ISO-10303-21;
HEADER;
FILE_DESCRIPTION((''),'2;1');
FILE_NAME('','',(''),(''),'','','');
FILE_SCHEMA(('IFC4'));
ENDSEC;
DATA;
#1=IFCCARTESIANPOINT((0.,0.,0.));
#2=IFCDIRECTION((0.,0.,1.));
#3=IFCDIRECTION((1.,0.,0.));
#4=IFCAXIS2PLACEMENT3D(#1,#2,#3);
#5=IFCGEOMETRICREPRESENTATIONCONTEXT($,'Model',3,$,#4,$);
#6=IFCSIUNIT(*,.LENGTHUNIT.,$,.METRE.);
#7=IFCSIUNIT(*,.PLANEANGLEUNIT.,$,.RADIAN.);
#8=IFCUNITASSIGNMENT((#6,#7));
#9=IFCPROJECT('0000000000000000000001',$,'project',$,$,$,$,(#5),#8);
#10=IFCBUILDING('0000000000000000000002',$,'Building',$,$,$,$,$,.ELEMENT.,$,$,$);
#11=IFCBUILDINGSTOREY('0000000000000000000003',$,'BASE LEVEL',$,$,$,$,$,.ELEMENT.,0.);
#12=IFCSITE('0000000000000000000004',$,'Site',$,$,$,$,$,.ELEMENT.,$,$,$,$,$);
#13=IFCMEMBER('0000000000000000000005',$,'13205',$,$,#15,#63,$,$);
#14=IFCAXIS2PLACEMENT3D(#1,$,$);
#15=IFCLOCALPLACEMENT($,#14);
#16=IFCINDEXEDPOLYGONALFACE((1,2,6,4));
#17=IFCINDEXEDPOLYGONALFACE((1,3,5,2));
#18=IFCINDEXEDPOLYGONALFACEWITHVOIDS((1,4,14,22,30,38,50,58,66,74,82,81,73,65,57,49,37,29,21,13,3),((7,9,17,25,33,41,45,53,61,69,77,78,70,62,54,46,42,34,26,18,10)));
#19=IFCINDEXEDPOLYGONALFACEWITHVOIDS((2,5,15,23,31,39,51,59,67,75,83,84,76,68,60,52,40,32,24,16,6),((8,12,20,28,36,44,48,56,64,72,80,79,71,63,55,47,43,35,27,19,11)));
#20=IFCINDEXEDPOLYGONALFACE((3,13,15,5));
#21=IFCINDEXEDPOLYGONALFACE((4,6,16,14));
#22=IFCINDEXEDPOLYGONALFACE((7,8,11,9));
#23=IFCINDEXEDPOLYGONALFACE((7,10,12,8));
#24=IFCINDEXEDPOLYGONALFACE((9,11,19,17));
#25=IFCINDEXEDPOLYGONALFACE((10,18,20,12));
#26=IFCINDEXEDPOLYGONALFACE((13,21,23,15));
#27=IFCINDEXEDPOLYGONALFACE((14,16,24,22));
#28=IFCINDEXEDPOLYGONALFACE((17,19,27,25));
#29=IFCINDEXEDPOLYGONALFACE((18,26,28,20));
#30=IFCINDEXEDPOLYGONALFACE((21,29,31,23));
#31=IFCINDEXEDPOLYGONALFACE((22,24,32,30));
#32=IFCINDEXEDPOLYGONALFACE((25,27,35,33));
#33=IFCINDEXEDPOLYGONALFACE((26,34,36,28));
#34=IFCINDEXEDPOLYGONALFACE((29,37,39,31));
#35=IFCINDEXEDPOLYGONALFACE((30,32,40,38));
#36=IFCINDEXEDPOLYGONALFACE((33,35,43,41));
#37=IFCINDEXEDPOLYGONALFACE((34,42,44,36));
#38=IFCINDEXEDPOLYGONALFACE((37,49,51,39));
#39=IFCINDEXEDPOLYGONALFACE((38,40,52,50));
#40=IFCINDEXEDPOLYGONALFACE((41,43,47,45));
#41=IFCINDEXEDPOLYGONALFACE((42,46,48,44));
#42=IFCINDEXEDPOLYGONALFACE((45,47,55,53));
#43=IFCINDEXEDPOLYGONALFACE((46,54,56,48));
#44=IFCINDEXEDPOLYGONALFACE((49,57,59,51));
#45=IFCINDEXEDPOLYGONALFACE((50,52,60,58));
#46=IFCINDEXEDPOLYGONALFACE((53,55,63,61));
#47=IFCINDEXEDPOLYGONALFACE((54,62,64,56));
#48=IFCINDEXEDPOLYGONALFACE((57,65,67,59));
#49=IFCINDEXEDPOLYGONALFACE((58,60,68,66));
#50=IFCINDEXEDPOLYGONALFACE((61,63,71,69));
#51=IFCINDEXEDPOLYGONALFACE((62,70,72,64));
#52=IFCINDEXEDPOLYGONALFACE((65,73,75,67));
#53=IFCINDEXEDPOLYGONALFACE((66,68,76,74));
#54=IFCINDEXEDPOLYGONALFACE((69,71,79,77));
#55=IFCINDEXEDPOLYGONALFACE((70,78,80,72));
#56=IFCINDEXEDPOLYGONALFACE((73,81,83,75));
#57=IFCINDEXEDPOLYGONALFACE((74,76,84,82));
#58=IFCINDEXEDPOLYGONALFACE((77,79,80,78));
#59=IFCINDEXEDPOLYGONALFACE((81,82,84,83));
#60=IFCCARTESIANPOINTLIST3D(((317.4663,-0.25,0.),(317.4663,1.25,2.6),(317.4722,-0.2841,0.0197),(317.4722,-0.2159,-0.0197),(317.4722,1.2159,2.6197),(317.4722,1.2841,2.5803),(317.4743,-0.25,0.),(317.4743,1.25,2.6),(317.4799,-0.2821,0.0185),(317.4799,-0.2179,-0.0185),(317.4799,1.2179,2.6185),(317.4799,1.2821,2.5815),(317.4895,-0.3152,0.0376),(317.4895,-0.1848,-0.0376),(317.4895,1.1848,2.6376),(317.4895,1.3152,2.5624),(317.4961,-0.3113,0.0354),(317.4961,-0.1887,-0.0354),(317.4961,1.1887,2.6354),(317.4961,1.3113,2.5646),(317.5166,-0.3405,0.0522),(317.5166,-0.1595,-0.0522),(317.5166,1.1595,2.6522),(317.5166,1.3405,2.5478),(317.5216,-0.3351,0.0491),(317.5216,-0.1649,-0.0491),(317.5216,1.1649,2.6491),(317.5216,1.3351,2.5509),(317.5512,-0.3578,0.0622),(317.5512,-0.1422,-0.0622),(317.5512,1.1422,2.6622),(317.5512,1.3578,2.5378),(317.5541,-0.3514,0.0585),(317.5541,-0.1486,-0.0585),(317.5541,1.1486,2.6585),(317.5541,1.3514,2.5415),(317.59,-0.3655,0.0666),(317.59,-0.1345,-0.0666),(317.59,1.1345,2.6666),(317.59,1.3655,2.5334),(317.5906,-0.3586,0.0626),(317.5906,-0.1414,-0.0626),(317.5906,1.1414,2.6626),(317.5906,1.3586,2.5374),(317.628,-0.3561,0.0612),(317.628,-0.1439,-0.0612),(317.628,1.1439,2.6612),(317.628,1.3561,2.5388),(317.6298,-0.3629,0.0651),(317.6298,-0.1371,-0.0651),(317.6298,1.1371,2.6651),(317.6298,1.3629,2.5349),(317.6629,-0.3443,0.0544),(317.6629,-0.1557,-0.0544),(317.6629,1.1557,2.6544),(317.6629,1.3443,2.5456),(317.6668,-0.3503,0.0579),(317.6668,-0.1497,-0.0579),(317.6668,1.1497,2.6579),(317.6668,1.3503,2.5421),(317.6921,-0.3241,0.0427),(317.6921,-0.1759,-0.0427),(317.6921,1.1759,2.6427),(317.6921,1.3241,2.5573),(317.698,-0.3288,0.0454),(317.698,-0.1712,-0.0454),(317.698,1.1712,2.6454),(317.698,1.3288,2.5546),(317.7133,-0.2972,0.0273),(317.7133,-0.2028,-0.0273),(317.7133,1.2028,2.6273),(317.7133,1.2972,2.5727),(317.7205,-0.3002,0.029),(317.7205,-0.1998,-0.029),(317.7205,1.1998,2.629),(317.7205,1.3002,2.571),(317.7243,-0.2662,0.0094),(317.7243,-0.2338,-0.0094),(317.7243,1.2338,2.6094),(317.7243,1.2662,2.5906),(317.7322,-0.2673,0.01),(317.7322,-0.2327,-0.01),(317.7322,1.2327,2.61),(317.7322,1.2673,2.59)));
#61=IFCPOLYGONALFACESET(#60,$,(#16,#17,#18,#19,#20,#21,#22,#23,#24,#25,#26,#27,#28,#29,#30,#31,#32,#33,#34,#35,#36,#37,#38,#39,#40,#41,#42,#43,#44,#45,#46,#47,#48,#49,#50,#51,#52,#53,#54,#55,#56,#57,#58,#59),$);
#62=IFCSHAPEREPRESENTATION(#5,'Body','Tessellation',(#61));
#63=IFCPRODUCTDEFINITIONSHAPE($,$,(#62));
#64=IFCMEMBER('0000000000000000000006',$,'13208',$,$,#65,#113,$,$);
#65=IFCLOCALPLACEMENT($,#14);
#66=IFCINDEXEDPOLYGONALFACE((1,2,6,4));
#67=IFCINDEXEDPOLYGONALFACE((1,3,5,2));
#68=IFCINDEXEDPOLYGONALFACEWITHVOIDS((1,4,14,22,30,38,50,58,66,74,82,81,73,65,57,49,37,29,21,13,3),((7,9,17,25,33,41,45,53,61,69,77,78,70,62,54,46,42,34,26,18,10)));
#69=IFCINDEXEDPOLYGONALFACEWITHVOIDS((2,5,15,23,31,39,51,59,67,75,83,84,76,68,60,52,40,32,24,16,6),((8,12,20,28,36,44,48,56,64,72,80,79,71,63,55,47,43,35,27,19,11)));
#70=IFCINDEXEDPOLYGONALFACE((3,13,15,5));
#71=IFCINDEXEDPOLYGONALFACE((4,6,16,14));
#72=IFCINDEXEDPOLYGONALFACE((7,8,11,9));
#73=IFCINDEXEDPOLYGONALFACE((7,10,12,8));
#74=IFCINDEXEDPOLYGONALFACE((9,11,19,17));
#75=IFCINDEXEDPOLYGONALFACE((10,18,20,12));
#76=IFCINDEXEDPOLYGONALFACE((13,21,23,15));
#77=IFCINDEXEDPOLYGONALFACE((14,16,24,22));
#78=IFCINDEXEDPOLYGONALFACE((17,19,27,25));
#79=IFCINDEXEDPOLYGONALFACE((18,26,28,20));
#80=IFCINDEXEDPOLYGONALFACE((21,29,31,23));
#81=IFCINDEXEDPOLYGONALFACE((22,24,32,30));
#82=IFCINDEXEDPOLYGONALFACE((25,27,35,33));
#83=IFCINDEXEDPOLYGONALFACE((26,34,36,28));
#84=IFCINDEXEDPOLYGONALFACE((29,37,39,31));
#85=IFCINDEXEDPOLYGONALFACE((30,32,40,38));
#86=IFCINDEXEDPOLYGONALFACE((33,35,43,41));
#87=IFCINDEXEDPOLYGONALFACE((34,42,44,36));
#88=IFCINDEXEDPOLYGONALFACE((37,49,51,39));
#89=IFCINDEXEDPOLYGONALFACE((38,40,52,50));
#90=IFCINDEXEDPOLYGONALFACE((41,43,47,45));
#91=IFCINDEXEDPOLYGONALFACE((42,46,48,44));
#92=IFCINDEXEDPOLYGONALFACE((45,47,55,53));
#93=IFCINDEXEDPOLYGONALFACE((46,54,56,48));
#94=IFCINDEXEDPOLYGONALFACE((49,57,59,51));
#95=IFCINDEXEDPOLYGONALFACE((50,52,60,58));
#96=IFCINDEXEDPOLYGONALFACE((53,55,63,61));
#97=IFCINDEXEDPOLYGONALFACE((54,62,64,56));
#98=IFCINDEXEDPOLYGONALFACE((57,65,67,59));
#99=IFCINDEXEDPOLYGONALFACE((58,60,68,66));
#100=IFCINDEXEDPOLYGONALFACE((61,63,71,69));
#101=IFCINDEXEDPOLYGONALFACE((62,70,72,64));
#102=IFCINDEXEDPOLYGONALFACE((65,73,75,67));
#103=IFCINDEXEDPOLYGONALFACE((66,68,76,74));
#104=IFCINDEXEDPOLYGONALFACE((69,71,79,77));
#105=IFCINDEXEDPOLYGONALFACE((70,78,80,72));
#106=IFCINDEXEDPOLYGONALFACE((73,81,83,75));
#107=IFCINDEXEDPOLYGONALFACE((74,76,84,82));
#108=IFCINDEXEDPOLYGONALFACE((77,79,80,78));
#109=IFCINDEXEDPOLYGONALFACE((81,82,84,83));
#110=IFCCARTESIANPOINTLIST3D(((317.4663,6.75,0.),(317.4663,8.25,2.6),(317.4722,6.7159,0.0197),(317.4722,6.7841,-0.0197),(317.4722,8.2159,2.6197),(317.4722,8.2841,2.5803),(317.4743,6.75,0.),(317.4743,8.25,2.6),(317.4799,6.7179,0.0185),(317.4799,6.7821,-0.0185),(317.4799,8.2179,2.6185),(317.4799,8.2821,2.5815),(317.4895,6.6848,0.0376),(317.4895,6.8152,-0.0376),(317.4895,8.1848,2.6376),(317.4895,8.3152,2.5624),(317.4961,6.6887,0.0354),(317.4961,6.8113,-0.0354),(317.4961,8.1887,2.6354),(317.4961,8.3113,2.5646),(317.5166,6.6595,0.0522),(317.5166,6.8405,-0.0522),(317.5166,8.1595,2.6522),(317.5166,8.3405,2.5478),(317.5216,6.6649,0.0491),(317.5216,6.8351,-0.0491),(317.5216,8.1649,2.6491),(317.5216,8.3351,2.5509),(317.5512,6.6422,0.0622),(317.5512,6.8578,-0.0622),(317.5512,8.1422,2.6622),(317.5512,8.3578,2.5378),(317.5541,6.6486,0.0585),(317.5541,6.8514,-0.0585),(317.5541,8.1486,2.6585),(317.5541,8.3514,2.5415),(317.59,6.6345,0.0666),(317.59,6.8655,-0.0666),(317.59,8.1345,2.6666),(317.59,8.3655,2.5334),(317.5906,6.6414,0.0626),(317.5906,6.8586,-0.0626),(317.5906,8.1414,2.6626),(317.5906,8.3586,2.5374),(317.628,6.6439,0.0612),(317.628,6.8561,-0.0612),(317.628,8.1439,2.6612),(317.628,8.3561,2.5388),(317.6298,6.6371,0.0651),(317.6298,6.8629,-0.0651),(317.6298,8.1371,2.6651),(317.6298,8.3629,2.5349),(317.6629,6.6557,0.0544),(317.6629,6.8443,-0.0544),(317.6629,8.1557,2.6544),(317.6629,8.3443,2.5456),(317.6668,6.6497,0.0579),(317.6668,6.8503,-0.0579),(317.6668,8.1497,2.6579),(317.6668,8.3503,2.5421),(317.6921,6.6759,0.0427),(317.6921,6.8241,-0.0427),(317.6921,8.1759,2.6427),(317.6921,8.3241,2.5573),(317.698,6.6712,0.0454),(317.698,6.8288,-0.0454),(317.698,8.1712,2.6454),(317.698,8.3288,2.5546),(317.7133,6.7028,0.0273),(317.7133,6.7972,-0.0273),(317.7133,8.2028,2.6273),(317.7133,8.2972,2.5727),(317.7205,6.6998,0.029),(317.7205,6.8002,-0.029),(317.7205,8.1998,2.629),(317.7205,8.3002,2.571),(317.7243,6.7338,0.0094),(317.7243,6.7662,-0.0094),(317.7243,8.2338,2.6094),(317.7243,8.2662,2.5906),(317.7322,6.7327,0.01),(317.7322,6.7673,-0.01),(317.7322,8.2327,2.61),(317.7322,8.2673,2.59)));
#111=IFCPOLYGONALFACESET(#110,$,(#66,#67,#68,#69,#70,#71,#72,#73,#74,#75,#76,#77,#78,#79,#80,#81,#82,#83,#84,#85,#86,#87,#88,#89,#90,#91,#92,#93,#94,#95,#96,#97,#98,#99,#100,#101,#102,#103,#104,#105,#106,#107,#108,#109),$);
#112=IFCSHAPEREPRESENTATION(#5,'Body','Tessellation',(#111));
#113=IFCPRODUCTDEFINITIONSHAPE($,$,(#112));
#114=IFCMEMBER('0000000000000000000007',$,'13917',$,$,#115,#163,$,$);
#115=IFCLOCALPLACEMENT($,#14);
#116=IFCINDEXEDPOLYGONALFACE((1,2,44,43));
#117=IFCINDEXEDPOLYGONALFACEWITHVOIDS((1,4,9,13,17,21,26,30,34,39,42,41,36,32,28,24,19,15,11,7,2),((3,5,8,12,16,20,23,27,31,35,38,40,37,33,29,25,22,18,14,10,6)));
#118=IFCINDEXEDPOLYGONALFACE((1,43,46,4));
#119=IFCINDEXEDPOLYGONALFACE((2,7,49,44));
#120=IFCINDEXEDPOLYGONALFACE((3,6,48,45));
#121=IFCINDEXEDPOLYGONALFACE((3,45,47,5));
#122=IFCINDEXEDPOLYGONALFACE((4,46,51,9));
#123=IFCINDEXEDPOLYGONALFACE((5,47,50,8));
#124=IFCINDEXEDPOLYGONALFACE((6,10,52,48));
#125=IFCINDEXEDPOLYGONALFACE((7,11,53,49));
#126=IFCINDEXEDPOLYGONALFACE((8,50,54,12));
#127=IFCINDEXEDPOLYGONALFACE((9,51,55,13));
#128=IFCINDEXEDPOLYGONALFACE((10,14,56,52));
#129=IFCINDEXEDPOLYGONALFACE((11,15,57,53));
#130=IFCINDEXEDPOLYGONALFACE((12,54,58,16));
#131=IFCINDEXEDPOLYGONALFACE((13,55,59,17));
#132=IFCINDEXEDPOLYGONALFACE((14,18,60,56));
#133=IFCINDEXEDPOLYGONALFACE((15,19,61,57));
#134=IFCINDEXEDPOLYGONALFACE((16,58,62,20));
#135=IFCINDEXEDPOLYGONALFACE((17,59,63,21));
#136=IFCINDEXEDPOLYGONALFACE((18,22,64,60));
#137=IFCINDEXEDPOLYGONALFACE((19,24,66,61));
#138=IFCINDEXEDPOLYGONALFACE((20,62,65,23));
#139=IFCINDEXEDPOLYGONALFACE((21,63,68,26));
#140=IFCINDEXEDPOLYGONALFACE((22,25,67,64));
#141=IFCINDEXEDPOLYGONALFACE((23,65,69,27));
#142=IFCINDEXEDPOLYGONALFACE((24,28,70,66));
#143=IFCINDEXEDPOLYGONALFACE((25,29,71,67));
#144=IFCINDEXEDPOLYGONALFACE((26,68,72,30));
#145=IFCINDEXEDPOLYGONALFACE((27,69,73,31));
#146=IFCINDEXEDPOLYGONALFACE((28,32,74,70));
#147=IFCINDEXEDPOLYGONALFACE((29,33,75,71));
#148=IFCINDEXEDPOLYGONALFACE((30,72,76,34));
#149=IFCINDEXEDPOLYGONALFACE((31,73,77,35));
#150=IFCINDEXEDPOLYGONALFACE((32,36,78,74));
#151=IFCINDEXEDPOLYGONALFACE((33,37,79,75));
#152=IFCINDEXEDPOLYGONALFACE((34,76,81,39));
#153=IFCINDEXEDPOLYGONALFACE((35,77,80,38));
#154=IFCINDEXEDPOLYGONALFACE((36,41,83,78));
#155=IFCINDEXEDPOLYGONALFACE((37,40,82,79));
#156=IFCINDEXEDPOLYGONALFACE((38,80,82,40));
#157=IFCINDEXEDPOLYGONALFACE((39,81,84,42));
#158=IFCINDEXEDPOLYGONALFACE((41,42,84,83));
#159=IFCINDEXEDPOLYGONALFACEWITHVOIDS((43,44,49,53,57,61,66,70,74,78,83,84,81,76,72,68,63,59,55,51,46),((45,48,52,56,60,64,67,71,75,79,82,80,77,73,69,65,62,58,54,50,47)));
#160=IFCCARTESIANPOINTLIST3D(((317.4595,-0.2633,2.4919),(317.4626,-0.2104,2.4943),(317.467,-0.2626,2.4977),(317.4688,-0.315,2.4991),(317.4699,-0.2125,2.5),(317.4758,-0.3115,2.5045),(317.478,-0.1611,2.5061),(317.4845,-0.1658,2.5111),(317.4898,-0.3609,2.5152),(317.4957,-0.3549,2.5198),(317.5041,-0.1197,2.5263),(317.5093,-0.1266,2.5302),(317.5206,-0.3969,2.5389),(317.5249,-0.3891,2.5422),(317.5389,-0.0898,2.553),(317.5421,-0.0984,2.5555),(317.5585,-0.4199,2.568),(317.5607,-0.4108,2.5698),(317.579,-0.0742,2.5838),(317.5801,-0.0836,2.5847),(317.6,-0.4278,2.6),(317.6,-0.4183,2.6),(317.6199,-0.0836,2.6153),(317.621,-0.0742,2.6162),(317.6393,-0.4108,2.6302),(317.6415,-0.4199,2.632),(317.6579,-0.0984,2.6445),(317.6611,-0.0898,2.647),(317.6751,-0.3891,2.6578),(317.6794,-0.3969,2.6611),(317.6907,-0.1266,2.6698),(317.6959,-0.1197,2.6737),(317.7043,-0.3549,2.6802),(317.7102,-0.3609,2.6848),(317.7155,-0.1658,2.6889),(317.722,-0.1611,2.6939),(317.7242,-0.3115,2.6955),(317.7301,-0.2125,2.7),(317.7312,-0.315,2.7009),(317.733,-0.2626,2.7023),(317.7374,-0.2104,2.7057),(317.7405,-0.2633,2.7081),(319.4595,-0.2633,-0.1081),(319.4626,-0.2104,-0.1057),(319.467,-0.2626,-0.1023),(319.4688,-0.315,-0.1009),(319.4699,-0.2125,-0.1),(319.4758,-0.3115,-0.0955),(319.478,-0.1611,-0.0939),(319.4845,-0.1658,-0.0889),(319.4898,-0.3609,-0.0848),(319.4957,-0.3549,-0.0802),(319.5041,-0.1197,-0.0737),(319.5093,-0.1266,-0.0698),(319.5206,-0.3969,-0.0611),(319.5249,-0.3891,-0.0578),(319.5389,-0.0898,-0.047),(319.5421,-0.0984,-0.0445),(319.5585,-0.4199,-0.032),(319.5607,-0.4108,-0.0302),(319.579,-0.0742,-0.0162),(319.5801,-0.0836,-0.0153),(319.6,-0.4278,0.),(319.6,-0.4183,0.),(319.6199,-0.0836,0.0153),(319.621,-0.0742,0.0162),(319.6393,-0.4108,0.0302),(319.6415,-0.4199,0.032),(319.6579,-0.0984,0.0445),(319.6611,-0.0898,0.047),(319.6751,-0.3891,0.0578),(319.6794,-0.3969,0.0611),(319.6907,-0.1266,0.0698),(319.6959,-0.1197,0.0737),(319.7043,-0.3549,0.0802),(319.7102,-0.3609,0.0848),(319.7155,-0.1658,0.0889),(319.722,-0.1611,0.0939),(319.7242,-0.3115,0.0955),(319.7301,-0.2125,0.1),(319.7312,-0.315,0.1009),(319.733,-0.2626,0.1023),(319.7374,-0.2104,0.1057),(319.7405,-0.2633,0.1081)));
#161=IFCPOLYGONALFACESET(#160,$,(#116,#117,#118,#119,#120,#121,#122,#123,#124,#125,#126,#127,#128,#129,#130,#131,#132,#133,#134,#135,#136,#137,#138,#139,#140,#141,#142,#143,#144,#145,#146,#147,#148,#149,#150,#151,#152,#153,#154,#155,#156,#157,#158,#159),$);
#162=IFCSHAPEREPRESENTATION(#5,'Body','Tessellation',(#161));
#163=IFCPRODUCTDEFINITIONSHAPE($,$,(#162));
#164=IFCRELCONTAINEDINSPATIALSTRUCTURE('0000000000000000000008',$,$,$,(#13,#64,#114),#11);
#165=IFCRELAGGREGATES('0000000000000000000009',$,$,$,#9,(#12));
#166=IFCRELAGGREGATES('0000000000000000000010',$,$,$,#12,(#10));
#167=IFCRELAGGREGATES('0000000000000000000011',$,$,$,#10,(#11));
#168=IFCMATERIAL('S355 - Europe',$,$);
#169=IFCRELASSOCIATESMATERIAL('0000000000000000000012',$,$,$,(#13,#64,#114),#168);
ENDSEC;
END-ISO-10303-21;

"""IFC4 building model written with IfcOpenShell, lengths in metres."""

from ifc_helpers import new_model, si_unit, frame, origin_with_axes, origin_2d_with_axis, place, context, project, spatial, hollow_circle, extrude, material, material_profile, profile_set, profile_usage, element, save


model = new_model("IFC4")

# Units and contexts
model_context = context("Model", 3, world=origin_with_axes())
ifc_project = project(units=[si_unit("LENGTHUNIT", "METRE"), si_unit("PLANEANGLEUNIT", "RADIAN")], contexts=[model_context])

# Site, building, storey
site = spatial("IfcSite", under=ifc_project, Name="Site", CompositionType="ELEMENT")
building = spatial("IfcBuilding", under=site, Name="Building", CompositionType="ELEMENT")
storey = spatial("IfcBuildingStorey", under=building, Name="BASE LEVEL", CompositionType="ELEMENT", Elevation=0.0)

# Shared definitions
ifc_material = material(Name="S355 - Europe")

# Members
ifc_material_profile_1 = material_profile(ifc_material, hollow_circle(Radius=0.1337, WallThickness=0.008, at=origin_2d_with_axis()))
ifc_profile_set_1 = profile_set([ifc_material_profile_1])
ifc_profile_usage_1 = profile_usage(ifc_profile_set_1, cardinal=10)
member_1_placement = place(None, frame((317.6, -0.25, 0.0), z_axis=(0.0, 0.499722, 0.866186), x_axis=(-1.0, 0.0, 0.0)))
element("IfcMember", 1, at=member_1_placement, inside=storey, material=ifc_profile_usage_1, Name="13205", context=model_context, shape_type="SweptSolid", body=[
    extrude(hollow_circle(Radius=0.1337, WallThickness=0.008, at=origin_2d_with_axis()), origin_with_axes(), (0.0, 0.0, 1.0), 3.0017),
])
ifc_material_profile_2 = material_profile(ifc_material, hollow_circle(Radius=0.1337, WallThickness=0.008, at=origin_2d_with_axis()))
ifc_profile_set_2 = profile_set([ifc_material_profile_2])
ifc_profile_usage_2 = profile_usage(ifc_profile_set_2, cardinal=10)
member_2_placement = place(None, frame((317.6, 6.75, 0.0), z_axis=(0.0, 0.499722, 0.866186), x_axis=(-1.0, 0.0, 0.0)))
element("IfcMember", 2, at=member_2_placement, inside=storey, material=ifc_profile_usage_2, Name="13208", context=model_context, shape_type="SweptSolid", body=[
    extrude(hollow_circle(Radius=0.1337, WallThickness=0.008, at=origin_2d_with_axis()), origin_with_axes(), (0.0, 0.0, 1.0), 3.0017),
])
ifc_material_profile_3 = material_profile(ifc_material, hollow_circle(Radius=0.1778, WallThickness=0.0095, at=origin_2d_with_axis()))
ifc_profile_set_3 = profile_set([ifc_material_profile_3])
ifc_profile_usage_3 = profile_usage(ifc_profile_set_3, cardinal=10)
member_3_placement = place(None, frame((319.6, -0.25, 0.0), z_axis=(-0.609711, 0.0, 0.792624), x_axis=(0.0, -1.0, 0.0)))
element("IfcMember", 3, at=member_3_placement, inside=storey, material=ifc_profile_usage_3, Name="13917", context=model_context, shape_type="SweptSolid", body=[
    extrude(hollow_circle(Radius=0.1778, WallThickness=0.0095, at=origin_2d_with_axis()), origin_with_axes(), (0.0, 0.0, 1.0), 3.2802),
])

save(model, "model.ifc")
